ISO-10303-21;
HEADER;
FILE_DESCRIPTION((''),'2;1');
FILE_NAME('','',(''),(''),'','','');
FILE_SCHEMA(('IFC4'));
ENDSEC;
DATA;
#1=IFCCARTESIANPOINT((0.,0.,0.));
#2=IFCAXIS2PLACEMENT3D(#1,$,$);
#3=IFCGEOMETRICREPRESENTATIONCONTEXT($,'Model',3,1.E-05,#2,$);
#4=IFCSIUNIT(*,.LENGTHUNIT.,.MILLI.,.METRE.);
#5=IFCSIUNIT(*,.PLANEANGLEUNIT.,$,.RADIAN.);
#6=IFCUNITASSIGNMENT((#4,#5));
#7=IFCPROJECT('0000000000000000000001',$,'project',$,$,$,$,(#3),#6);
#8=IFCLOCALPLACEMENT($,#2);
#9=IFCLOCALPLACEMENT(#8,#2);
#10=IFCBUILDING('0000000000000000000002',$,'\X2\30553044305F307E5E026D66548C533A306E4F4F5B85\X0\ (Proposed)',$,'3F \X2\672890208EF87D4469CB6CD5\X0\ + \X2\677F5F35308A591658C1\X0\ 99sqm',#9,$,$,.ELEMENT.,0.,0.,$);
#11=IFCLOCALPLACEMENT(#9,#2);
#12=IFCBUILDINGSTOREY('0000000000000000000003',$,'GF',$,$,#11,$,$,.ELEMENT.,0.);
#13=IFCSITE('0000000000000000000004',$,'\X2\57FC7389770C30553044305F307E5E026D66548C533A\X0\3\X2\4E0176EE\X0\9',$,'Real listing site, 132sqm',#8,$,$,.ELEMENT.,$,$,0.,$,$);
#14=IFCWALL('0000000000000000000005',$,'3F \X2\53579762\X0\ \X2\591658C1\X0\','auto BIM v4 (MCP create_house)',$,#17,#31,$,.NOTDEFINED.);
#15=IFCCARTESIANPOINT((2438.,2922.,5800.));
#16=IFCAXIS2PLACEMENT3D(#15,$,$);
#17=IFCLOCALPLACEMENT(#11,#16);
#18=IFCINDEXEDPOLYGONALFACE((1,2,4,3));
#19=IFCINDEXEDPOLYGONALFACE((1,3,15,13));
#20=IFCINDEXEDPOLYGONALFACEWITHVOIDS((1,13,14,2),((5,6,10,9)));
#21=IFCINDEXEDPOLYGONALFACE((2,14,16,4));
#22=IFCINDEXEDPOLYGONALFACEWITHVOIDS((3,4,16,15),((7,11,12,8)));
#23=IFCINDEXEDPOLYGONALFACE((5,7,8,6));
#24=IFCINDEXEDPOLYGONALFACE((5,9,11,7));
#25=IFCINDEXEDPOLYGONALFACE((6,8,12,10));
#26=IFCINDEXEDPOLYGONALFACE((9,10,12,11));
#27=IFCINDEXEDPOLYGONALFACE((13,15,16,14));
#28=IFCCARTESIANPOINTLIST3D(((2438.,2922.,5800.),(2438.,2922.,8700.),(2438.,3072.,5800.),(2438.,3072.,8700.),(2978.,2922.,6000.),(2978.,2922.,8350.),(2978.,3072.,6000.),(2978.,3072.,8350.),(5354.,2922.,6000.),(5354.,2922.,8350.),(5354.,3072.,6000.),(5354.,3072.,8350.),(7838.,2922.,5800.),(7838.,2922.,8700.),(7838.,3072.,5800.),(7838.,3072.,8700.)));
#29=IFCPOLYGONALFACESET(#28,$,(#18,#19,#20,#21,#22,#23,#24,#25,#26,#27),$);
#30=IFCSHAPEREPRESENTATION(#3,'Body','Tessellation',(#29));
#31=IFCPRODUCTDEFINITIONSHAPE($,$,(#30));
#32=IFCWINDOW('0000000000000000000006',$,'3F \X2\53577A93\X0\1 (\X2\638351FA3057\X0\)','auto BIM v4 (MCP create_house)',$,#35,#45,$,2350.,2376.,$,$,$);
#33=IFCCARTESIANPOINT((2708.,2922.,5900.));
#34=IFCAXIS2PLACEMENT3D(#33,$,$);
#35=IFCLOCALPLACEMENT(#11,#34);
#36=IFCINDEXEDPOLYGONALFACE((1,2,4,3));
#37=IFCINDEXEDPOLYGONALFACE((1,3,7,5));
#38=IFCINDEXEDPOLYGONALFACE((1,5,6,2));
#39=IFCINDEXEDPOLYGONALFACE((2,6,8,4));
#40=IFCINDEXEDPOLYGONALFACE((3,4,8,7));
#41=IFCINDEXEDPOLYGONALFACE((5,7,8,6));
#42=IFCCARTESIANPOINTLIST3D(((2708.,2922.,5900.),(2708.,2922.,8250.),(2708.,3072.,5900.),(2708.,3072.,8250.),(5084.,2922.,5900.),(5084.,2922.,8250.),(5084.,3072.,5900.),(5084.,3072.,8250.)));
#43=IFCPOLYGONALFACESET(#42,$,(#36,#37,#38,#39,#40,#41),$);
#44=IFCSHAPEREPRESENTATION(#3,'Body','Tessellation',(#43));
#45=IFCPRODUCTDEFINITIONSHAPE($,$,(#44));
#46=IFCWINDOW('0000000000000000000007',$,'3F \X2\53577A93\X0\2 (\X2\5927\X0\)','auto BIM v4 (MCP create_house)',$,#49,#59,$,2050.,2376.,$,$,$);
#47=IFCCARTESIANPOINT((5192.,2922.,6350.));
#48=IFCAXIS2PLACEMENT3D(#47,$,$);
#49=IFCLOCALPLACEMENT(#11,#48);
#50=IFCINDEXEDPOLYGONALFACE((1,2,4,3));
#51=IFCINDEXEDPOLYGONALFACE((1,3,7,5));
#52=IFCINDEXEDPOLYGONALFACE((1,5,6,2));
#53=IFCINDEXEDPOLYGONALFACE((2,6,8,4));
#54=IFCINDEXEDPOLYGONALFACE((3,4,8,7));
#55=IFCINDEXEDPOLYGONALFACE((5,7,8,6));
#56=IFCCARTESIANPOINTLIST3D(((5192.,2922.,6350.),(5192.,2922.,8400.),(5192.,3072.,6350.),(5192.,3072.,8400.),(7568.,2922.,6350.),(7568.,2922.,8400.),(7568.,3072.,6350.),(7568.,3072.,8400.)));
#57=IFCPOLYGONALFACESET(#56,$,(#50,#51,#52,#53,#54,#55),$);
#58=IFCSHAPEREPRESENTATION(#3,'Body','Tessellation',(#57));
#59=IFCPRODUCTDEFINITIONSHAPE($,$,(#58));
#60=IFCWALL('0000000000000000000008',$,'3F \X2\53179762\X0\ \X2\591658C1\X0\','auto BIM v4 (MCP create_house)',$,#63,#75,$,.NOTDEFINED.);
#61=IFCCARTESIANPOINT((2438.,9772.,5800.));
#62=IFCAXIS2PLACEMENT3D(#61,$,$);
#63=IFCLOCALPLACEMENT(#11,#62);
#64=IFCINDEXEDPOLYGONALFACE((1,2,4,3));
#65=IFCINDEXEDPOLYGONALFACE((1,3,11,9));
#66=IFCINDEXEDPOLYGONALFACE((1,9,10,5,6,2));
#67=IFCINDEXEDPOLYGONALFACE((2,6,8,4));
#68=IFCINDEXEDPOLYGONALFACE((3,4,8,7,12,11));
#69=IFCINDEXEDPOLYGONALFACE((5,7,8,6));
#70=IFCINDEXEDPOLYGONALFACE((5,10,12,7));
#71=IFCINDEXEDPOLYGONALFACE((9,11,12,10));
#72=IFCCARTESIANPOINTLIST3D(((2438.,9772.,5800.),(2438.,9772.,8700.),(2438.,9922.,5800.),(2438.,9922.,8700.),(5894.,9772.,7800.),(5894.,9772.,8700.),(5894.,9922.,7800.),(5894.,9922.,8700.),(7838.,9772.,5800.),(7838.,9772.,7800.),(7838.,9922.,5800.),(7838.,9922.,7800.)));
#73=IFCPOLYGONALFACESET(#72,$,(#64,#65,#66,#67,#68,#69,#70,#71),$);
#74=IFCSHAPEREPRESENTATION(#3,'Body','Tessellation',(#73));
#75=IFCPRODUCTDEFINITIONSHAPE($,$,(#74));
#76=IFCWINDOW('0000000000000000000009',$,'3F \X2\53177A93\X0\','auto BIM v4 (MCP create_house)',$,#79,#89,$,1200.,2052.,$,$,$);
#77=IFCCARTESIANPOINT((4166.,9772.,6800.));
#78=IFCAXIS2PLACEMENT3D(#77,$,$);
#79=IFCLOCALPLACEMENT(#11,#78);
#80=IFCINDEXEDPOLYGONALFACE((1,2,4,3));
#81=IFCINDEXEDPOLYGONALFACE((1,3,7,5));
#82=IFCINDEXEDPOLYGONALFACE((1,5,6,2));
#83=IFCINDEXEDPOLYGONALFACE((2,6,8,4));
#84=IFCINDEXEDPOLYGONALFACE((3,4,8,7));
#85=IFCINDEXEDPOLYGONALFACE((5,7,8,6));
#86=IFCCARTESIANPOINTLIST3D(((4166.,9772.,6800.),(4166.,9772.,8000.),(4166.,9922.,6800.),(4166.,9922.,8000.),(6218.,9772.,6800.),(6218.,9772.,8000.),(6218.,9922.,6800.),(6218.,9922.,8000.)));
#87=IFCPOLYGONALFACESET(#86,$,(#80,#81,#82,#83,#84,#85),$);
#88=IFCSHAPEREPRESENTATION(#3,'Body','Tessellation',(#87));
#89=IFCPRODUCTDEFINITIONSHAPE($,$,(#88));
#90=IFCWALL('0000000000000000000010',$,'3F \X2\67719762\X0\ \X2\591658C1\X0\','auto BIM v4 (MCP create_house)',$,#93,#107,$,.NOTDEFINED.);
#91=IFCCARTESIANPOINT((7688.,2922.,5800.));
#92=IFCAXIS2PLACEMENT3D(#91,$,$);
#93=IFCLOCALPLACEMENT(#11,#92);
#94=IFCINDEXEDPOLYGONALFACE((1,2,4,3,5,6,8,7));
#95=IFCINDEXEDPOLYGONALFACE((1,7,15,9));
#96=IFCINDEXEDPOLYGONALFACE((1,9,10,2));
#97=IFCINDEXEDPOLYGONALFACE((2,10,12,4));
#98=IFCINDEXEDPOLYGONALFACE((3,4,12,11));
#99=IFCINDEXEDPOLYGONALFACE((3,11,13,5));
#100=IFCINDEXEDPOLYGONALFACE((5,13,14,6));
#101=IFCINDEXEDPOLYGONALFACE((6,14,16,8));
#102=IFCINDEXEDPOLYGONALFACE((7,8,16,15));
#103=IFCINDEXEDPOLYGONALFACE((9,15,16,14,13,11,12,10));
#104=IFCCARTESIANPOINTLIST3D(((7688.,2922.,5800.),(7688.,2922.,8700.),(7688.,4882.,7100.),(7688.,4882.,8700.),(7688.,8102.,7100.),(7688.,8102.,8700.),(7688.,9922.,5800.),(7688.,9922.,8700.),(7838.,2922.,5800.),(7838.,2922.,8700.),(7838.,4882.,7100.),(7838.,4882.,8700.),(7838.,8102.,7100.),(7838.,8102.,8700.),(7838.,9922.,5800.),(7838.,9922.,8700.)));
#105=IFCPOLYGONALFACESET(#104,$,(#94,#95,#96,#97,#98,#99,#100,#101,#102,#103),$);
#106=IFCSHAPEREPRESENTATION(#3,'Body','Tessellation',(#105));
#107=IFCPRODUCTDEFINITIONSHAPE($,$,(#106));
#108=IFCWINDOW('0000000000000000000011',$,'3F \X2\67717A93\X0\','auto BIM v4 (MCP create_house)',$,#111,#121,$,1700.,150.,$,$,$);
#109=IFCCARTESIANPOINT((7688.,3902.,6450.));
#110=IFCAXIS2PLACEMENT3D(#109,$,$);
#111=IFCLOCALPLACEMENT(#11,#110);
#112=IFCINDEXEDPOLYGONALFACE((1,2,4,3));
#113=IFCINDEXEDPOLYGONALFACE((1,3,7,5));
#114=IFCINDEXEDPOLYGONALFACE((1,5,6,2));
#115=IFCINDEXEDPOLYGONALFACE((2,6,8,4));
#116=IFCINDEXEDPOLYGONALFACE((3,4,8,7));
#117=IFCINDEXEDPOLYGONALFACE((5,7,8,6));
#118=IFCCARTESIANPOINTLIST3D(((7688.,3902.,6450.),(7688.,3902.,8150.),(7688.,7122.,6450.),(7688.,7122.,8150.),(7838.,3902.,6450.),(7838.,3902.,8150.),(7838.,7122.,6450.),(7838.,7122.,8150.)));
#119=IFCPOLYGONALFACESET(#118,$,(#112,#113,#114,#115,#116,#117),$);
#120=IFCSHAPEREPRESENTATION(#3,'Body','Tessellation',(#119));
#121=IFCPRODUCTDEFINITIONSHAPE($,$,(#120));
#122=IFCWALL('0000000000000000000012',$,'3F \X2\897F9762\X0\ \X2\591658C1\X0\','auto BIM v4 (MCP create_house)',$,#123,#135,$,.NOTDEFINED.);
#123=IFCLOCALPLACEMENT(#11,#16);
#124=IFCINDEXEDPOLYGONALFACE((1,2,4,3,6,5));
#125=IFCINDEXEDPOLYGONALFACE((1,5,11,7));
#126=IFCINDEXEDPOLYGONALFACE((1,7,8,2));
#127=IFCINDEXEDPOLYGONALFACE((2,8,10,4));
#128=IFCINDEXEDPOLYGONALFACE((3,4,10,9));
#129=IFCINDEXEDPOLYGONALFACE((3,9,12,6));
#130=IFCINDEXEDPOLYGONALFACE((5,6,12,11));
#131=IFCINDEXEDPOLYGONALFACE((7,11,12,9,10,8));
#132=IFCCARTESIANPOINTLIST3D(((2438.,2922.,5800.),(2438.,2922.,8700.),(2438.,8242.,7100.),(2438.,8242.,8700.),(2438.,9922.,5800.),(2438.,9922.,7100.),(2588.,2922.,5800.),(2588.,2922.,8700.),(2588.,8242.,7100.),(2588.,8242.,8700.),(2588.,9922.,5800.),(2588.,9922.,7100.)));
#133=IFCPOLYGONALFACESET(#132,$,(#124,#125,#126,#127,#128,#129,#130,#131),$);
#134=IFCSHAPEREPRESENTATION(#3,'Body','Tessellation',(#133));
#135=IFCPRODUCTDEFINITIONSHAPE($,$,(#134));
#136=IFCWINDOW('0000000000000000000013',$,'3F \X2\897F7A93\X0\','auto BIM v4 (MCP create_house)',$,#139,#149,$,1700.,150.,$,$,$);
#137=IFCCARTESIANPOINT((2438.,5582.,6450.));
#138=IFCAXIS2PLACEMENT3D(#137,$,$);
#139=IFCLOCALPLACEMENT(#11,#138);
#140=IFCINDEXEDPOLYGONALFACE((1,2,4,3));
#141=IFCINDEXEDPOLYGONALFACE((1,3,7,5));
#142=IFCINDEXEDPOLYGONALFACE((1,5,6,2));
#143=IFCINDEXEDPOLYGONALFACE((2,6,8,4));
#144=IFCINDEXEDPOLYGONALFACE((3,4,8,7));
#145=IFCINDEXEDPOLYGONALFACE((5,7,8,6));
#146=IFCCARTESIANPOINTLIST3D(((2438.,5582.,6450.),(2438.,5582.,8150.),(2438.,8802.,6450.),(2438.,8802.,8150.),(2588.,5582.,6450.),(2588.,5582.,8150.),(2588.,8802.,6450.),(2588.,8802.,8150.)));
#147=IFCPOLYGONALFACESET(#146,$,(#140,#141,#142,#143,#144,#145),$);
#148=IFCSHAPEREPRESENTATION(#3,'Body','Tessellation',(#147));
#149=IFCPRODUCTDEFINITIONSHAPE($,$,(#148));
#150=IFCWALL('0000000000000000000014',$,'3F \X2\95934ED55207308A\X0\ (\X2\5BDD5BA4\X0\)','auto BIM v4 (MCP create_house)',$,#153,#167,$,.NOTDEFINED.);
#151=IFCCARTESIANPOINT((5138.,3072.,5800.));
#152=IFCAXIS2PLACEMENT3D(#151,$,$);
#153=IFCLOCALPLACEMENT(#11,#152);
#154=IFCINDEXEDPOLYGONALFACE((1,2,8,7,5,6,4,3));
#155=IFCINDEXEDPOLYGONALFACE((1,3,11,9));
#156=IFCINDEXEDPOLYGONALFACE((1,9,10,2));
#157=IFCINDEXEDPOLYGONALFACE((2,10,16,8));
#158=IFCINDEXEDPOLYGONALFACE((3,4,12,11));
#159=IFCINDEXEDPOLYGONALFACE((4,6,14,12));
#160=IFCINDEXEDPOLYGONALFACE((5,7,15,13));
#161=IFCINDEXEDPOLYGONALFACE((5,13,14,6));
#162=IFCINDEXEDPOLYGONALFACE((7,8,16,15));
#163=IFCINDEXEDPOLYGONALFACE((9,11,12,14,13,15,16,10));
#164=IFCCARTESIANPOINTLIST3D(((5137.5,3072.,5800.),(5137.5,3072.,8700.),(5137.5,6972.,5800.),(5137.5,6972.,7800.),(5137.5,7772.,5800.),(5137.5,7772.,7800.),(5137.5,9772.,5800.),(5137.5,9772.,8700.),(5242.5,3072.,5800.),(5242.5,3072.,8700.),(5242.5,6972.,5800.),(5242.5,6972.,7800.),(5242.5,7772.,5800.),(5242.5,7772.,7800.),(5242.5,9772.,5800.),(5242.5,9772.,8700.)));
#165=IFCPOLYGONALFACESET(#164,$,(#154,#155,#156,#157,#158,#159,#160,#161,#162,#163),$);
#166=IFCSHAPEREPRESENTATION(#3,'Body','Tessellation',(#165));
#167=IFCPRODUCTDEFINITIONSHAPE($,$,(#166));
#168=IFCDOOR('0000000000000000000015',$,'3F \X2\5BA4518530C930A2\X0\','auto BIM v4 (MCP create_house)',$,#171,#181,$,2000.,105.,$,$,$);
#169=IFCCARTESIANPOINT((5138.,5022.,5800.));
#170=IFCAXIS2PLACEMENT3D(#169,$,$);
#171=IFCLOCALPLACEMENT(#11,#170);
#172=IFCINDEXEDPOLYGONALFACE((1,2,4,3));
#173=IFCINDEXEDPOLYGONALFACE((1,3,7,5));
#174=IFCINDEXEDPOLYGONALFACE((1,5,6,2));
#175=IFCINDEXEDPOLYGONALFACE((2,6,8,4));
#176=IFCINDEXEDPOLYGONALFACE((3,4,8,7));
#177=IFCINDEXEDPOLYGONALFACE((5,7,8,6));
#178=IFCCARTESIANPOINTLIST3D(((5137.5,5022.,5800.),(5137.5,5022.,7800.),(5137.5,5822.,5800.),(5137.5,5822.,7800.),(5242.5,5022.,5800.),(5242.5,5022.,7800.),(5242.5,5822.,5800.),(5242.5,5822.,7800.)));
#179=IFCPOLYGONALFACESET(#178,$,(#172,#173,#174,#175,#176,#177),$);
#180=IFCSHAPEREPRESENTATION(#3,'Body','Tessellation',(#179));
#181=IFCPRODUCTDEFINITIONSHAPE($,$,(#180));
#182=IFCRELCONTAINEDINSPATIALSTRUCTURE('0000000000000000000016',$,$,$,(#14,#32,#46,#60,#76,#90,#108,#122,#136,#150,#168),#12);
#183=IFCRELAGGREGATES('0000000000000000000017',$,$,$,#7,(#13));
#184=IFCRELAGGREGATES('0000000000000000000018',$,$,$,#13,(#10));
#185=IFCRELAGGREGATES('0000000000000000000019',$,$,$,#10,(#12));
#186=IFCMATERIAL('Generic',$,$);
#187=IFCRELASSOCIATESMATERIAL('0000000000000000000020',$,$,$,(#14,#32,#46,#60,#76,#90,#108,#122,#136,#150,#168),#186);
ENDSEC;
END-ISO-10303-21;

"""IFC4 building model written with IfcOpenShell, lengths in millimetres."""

from ifc_helpers import new_model, si_unit, frame, frame_2d, origin, place, context, project, spatial, rectangle, extrude, material, element, fill, save


model = new_model("IFC4")

# Units and contexts
model_context = context("Model", 3, precision=1e-05, world=origin())
ifc_project = project(units=[si_unit("LENGTHUNIT", "METRE", prefix="MILLI"), si_unit("PLANEANGLEUNIT", "RADIAN")], contexts=[model_context])

# Site, building, storey
site_placement = place(None, origin())
site = spatial("IfcSite", under=ifc_project, at=site_placement, Name="埼玉県さいたま市浦和区3丁目9", ObjectType="Real listing site, 132sqm", CompositionType="ELEMENT", RefElevation=0.0)
building_placement = place(site_placement, origin())
building = spatial("IfcBuilding", under=site, at=building_placement, Name="さいたま市浦和区の住宅 (Proposed)", ObjectType="3F 木造軸組構法 + 板張り外壁 99sqm", CompositionType="ELEMENT", ElevationOfRefHeight=0.0, ElevationOfTerrain=0.0)
storey_placement = place(building_placement, origin())
storey = spatial("IfcBuildingStorey", under=building, at=storey_placement, Name="GF", CompositionType="ELEMENT", Elevation=0.0)

# Shared definitions
ifc_material = material(Name="Generic")

# Wall, openings, windows
wall_1_placement = place(storey_placement, frame((2438.0, 2922.0, 5800.0)))
wall_1 = element("IfcWall", 1, at=wall_1_placement, inside=storey, material=ifc_material, Name="3F 南面 外壁", Description="auto BIM v4 (MCP create_house)", PredefinedType="NOTDEFINED", context=model_context, shape_type="SweptSolid", body=[
    extrude(rectangle(XDim=5400.0, YDim=150.0, at=frame_2d((2700.0, 75.0))), frame((2438.0, 2922.0, 5800.0)), (0.0, 0.0, 1.0), 2900.0),
])
opening_1_placement = place(storey_placement, frame((2708.0, 2922.0, 5900.0)))
opening_1 = element("IfcOpeningElement", 2, at=opening_1_placement, cuts=wall_1, PredefinedType="NOTDEFINED", context=model_context, shape_type="SweptSolid", body=[
    extrude(rectangle(XDim=2376.0, YDim=150.0, at=frame_2d((1188.0, 75.0))), frame((2708.0, 2922.0, 5900.0)), (0.0, 0.0, 1.0), 2350.0),
])
opening_2_placement = place(storey_placement, frame((5192.0, 2922.0, 6350.0)))
opening_2 = element("IfcOpeningElement", 3, at=opening_2_placement, cuts=wall_1, PredefinedType="NOTDEFINED", context=model_context, shape_type="SweptSolid", body=[
    extrude(rectangle(XDim=2376.0, YDim=150.0, at=frame_2d((1188.0, 75.0))), frame((5192.0, 2922.0, 6350.0)), (0.0, 0.0, 1.0), 2050.0),
])
window_1_placement = place(storey_placement, frame((2708.0, 2922.0, 5900.0)))
window_1 = element("IfcWindow", 4, at=window_1_placement, inside=storey, material=ifc_material, Name="3F 南窓1 (掃出し)", Description="auto BIM v4 (MCP create_house)", OverallHeight=2350.0, OverallWidth=2376.0, context=model_context, shape_type="SweptSolid", body=[
    extrude(rectangle(XDim=2376.0, YDim=150.0, at=frame_2d((1188.0, 75.0))), frame((2708.0, 2922.0, 5900.0)), (0.0, 0.0, 1.0), 2350.0),
])
fill(opening_1, window_1)
window_2_placement = place(storey_placement, frame((5192.0, 2922.0, 6350.0)))
window_2 = element("IfcWindow", 5, at=window_2_placement, inside=storey, material=ifc_material, Name="3F 南窓2 (大)", Description="auto BIM v4 (MCP create_house)", OverallHeight=2050.0, OverallWidth=2376.0, context=model_context, shape_type="SweptSolid", body=[
    extrude(rectangle(XDim=2376.0, YDim=150.0, at=frame_2d((1188.0, 75.0))), frame((5192.0, 2922.0, 6350.0)), (0.0, 0.0, 1.0), 2050.0),
])
fill(opening_2, window_2)

# Walls, openings, windows
wall_2_placement = place(storey_placement, frame((2438.0, 9772.0, 5800.0)))
wall_2 = element("IfcWall", 6, at=wall_2_placement, inside=storey, material=ifc_material, Name="3F 北面 外壁", Description="auto BIM v4 (MCP create_house)", PredefinedType="NOTDEFINED", context=model_context, shape_type="SweptSolid", body=[
    extrude(rectangle(XDim=5400.0, YDim=150.0, at=frame_2d((2700.0, 75.0))), frame((2438.0, 9772.0, 5800.0)), (0.0, 0.0, 1.0), 2900.0),
])
opening_3_placement = place(storey_placement, frame((4166.0, 9772.0, 6800.0)))
opening_3 = element("IfcOpeningElement", 7, at=opening_3_placement, cuts=wall_2, PredefinedType="NOTDEFINED", context=model_context, shape_type="SweptSolid", body=[
    extrude(rectangle(XDim=2052.0, YDim=150.0, at=frame_2d((1026.0, 75.0))), frame((4166.0, 9772.0, 6800.0)), (0.0, 0.0, 1.0), 1200.0),
])
window_3_placement = place(storey_placement, frame((4166.0, 9772.0, 6800.0)))
window_3 = element("IfcWindow", 8, at=window_3_placement, inside=storey, material=ifc_material, Name="3F 北窓", Description="auto BIM v4 (MCP create_house)", OverallHeight=1200.0, OverallWidth=2052.0, context=model_context, shape_type="SweptSolid", body=[
    extrude(rectangle(XDim=2052.0, YDim=150.0, at=frame_2d((1026.0, 75.0))), frame((4166.0, 9772.0, 6800.0)), (0.0, 0.0, 1.0), 1200.0),
])
fill(opening_3, window_3)
wall_3_placement = place(storey_placement, frame((7688.0, 2922.0, 5800.0)))
wall_3 = element("IfcWall", 9, at=wall_3_placement, inside=storey, material=ifc_material, Name="3F 東面 外壁", Description="auto BIM v4 (MCP create_house)", PredefinedType="NOTDEFINED", context=model_context, shape_type="SweptSolid", body=[
    extrude(rectangle(XDim=150.0, YDim=7000.0, at=frame_2d((75.0, 3500.0))), frame((7688.0, 2922.0, 5800.0)), (0.0, 0.0, 1.0), 2900.0),
])
opening_4_placement = place(storey_placement, frame((7688.0, 3902.0, 6450.0)))
opening_4 = element("IfcOpeningElement", 10, at=opening_4_placement, cuts=wall_3, PredefinedType="NOTDEFINED", context=model_context, shape_type="SweptSolid", body=[
    extrude(rectangle(XDim=150.0, YDim=3220.0, at=frame_2d((75.0, 1610.0))), frame((7688.0, 3902.0, 6450.0)), (0.0, 0.0, 1.0), 1700.0),
])
window_4_placement = place(storey_placement, frame((7688.0, 3902.0, 6450.0)))
window_4 = element("IfcWindow", 11, at=window_4_placement, inside=storey, material=ifc_material, Name="3F 東窓", Description="auto BIM v4 (MCP create_house)", OverallHeight=1700.0, OverallWidth=150.0, context=model_context, shape_type="SweptSolid", body=[
    extrude(rectangle(XDim=150.0, YDim=3220.0, at=frame_2d((75.0, 1610.0))), frame((7688.0, 3902.0, 6450.0)), (0.0, 0.0, 1.0), 1700.0),
])
fill(opening_4, window_4)
wall_4_placement = place(storey_placement, frame((2438.0, 2922.0, 5800.0)))
wall_4 = element("IfcWall", 12, at=wall_4_placement, inside=storey, material=ifc_material, Name="3F 西面 外壁", Description="auto BIM v4 (MCP create_house)", PredefinedType="NOTDEFINED", context=model_context, shape_type="SweptSolid", body=[
    extrude(rectangle(XDim=150.0, YDim=7000.0, at=frame_2d((75.0, 3500.0))), frame((2438.0, 2922.0, 5800.0)), (0.0, 0.0, 1.0), 2900.0),
])
opening_5_placement = place(storey_placement, frame((2438.0, 5582.0, 6450.0)))
opening_5 = element("IfcOpeningElement", 13, at=opening_5_placement, cuts=wall_4, PredefinedType="NOTDEFINED", context=model_context, shape_type="SweptSolid", body=[
    extrude(rectangle(XDim=150.0, YDim=3220.0, at=frame_2d((75.0, 1610.0))), frame((2438.0, 5582.0, 6450.0)), (0.0, 0.0, 1.0), 1700.0),
])
window_5_placement = place(storey_placement, frame((2438.0, 5582.0, 6450.0)))
window_5 = element("IfcWindow", 14, at=window_5_placement, inside=storey, material=ifc_material, Name="3F 西窓", Description="auto BIM v4 (MCP create_house)", OverallHeight=1700.0, OverallWidth=150.0, context=model_context, shape_type="SweptSolid", body=[
    extrude(rectangle(XDim=150.0, YDim=3220.0, at=frame_2d((75.0, 1610.0))), frame((2438.0, 5582.0, 6450.0)), (0.0, 0.0, 1.0), 1700.0),
])
fill(opening_5, window_5)

# Wall, opening, door
wall_5_placement = place(storey_placement, frame((5138.0, 3072.0, 5800.0)))
wall_5 = element("IfcWall", 15, at=wall_5_placement, inside=storey, material=ifc_material, Name="3F 間仕切り (寝室)", Description="auto BIM v4 (MCP create_house)", PredefinedType="NOTDEFINED", context=model_context, shape_type="SweptSolid", body=[
    extrude(rectangle(XDim=105.0, YDim=6700.0, at=frame_2d((52.0, 3350.0))), frame((5138.0, 3072.0, 5800.0)), (0.0, 0.0, 1.0), 2900.0),
])
opening_6_placement = place(storey_placement, frame((5138.0, 5022.0, 5800.0)))
opening_6 = element("IfcOpeningElement", 16, at=opening_6_placement, cuts=wall_5, PredefinedType="NOTDEFINED", context=model_context, shape_type="SweptSolid", body=[
    extrude(rectangle(XDim=105.0, YDim=800.0, at=frame_2d((52.0, 400.0))), frame((5138.0, 5022.0, 5800.0)), (0.0, 0.0, 1.0), 2000.0),
])
door_1_placement = place(storey_placement, frame((5138.0, 5022.0, 5800.0)))
door_1 = element("IfcDoor", 17, at=door_1_placement, inside=storey, material=ifc_material, Name="3F 室内ドア", Description="auto BIM v4 (MCP create_house)", OverallHeight=2000.0, OverallWidth=105.0, context=model_context, shape_type="SweptSolid", body=[
    extrude(rectangle(XDim=105.0, YDim=800.0, at=frame_2d((52.0, 400.0))), frame((5138.0, 5022.0, 5800.0)), (0.0, 0.0, 1.0), 2000.0),
])
fill(opening_6, door_1)

save(model, "model.ifc")
